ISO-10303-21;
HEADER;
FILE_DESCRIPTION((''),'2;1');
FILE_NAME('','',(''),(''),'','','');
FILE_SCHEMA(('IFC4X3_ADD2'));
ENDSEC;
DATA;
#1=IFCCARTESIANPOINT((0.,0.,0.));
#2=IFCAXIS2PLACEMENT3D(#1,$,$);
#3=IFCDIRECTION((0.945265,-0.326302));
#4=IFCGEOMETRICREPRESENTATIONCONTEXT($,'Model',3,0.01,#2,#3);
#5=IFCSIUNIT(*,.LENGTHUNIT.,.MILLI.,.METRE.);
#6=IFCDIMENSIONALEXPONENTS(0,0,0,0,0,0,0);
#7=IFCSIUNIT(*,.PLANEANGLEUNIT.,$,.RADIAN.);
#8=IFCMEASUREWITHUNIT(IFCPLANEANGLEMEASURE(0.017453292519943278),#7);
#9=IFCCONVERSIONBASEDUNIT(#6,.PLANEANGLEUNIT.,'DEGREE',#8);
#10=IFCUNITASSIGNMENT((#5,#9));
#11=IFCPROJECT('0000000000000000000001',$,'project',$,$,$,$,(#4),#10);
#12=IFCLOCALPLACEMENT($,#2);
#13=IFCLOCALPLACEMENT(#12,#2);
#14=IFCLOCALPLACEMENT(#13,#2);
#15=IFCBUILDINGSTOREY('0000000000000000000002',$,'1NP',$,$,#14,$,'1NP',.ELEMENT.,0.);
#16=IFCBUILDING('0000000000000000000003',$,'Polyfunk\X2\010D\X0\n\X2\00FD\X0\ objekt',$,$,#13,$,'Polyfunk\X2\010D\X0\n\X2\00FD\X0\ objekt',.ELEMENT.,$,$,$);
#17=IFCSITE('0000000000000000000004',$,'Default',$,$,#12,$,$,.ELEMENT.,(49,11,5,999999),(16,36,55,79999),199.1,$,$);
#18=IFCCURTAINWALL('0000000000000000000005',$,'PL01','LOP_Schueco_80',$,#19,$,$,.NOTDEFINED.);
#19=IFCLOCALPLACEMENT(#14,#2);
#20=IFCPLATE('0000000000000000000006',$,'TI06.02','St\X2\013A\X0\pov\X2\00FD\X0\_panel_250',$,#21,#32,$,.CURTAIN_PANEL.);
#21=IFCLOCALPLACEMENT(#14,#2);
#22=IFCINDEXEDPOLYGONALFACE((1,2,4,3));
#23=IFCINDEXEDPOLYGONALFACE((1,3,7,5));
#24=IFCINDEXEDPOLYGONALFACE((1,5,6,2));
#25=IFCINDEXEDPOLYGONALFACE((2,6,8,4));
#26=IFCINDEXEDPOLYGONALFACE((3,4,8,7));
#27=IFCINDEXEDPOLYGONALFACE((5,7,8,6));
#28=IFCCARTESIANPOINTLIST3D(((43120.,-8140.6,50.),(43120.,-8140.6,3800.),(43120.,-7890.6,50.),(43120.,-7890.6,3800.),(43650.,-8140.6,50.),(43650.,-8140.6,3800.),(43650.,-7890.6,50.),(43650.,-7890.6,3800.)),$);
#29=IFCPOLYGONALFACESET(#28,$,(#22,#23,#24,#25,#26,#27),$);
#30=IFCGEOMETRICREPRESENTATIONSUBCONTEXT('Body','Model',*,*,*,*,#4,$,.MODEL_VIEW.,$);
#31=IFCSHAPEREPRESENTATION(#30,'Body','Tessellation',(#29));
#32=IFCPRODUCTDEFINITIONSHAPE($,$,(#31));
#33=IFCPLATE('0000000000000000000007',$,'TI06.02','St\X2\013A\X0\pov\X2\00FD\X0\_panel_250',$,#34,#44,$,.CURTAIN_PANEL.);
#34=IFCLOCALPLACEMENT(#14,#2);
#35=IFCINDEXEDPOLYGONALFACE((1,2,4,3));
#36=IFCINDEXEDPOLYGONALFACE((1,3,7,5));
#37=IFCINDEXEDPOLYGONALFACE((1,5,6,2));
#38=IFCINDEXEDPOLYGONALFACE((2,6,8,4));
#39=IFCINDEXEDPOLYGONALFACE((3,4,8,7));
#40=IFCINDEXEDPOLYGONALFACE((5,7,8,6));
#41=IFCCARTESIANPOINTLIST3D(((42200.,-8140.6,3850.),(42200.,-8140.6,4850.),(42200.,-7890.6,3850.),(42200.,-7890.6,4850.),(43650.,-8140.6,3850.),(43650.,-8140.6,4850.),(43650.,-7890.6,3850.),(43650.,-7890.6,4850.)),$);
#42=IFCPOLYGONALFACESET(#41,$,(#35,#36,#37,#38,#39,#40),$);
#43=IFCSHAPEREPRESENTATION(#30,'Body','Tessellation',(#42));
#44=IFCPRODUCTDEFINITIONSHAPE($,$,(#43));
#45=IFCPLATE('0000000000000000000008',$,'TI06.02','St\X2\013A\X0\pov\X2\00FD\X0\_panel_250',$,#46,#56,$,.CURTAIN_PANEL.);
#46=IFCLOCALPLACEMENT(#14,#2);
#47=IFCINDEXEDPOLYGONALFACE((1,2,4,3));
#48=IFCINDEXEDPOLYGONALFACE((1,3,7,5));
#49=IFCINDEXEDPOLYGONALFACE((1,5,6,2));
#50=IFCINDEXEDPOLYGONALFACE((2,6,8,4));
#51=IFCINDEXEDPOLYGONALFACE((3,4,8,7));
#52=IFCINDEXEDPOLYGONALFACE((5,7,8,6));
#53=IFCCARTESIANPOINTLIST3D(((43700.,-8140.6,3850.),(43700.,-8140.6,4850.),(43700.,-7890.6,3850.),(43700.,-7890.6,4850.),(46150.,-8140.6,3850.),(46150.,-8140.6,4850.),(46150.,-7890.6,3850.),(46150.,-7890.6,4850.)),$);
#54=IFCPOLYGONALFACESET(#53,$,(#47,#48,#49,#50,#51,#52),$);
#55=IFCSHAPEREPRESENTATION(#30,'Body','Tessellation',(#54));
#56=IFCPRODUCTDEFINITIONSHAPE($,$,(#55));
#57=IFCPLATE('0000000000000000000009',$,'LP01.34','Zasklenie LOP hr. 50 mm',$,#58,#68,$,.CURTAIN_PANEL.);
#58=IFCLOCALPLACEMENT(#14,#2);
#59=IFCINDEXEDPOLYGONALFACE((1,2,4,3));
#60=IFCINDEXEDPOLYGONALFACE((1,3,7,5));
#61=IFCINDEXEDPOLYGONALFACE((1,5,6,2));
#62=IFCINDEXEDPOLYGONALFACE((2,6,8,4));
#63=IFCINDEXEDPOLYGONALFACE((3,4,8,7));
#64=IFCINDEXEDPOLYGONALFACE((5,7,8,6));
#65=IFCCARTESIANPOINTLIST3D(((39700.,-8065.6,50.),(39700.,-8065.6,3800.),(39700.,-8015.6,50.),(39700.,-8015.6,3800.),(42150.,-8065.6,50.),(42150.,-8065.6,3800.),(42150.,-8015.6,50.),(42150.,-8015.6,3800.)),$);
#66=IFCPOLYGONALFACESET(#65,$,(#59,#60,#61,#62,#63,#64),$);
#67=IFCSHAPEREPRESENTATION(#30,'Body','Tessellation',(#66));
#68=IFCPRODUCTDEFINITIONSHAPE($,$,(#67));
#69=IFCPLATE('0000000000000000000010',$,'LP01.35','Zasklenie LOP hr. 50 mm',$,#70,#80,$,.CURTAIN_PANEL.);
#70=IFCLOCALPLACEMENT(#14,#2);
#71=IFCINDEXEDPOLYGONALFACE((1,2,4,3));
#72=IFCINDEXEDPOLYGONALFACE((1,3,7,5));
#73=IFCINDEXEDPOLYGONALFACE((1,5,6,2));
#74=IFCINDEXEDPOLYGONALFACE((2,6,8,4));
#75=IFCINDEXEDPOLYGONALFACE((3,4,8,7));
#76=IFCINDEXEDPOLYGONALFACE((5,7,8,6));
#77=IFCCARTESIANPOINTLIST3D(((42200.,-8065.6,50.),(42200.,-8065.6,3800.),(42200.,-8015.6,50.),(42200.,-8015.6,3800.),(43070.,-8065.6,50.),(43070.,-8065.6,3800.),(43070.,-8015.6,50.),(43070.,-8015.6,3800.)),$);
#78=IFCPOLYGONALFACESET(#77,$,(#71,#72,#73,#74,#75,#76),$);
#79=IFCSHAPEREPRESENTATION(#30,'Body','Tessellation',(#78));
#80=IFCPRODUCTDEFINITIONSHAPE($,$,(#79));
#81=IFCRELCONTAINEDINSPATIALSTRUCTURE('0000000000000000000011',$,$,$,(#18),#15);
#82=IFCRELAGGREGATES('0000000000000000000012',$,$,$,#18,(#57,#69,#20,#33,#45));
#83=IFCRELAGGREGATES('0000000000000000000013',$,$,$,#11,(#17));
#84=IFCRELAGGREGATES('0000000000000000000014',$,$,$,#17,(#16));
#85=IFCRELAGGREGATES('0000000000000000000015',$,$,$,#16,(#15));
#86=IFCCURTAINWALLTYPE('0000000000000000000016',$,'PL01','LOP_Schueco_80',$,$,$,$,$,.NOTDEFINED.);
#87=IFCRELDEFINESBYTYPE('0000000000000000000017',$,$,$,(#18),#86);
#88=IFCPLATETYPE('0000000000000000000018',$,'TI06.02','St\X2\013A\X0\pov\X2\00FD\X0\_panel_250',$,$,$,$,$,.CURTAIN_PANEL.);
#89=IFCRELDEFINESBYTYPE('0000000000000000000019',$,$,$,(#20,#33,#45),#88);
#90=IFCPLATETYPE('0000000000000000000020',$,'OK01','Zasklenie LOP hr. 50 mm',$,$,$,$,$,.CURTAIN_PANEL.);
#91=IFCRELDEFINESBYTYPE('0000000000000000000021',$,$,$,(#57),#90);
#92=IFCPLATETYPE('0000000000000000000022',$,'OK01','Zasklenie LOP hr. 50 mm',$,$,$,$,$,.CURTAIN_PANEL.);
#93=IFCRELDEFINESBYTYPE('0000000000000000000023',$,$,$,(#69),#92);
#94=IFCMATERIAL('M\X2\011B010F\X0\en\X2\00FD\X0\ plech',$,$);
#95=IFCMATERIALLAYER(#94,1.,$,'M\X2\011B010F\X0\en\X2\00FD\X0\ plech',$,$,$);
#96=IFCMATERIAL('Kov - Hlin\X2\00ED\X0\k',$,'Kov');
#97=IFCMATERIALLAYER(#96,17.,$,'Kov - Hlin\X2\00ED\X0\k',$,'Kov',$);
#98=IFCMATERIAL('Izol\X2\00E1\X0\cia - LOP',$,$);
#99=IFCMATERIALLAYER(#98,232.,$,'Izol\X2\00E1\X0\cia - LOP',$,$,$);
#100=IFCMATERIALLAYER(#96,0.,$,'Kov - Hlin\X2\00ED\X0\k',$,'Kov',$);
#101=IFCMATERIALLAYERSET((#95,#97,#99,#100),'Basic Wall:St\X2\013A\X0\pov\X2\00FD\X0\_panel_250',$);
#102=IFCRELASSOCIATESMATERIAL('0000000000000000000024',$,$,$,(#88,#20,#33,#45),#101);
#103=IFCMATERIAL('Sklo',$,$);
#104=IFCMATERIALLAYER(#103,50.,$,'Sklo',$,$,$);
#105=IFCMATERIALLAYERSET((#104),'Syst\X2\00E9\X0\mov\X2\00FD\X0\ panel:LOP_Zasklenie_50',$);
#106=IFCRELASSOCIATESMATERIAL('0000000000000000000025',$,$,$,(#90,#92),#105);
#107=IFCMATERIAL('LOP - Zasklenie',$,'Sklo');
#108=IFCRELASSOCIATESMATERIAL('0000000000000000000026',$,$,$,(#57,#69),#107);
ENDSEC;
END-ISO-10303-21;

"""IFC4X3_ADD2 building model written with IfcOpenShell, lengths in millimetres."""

from ifc_helpers import new_model, entity, si_unit, converted_unit, direction, frame, frame_2d, origin, place, context, subcontext, project, spatial, rectangle, extrude, source, transform, mapped, material, layer, layer_set, layer_usage, type_object, type_shapes, element, aggregate, save


model = new_model("IFC4X3_ADD2")

# Units and contexts
model_context = context("Model", 3, precision=0.01, world=origin(), true_north=direction((0.945265, -0.326302)))
body_context = subcontext(model_context, "Body", "Model", "MODEL_VIEW")
ifc_project = project(units=[si_unit("LENGTHUNIT", "METRE", prefix="MILLI"), converted_unit("PLANEANGLEUNIT", "DEGREE", entity("IfcPlaneAngleMeasure", 0.017453292519943278), si_unit("PLANEANGLEUNIT", "RADIAN"), dimensions=[0, 0, 0, 0, 0, 0, 0])], contexts=[model_context])

# Site, building, storey
site_placement = place(None, origin())
site = spatial("IfcSite", under=ifc_project, at=site_placement, Name="Default", CompositionType="ELEMENT", RefLatitude=(49, 11, 5, 999999), RefLongitude=(16, 36, 55, 79999), RefElevation=199.1)
building_placement = place(site_placement, origin())
building = spatial("IfcBuilding", under=site, at=building_placement, Name="Polyfunkčný objekt", LongName="Polyfunkčný objekt", CompositionType="ELEMENT")
storey_placement = place(building_placement, origin())
storey = spatial("IfcBuildingStorey", under=building, at=storey_placement, Name="1NP", LongName="1NP", CompositionType="ELEMENT", Elevation=0.0)

# Curtain wall, plates
curtain_wall_type = type_object("IfcCurtainWallType", Name="PL01", Description="LOP_Schueco_80", PredefinedType="NOTDEFINED")
curtain_wall_placement = place(storey_placement, origin())
curtain_wall = element("IfcCurtainWall", 1, at=curtain_wall_placement, inside=storey, type_object=curtain_wall_type, Name="PL01", Description="LOP_Schueco_80", PredefinedType="NOTDEFINED")
ifc_material_1 = material(Name="Měďený plech")
ifc_layer_1 = layer(ifc_material_1, 1.0, Name="Měďený plech")
ifc_material_2 = material(Name="Kov - Hliník", Category="Kov")
ifc_layer_2 = layer(ifc_material_2, 17.0, Name="Kov - Hliník", Category="Kov")
ifc_material_3 = material(Name="Izolácia - LOP")
ifc_layer_3 = layer(ifc_material_3, 232.0, Name="Izolácia - LOP")
ifc_layer_4 = layer(ifc_material_2, 0.0, Name="Kov - Hliník", Category="Kov")
ifc_layer_set_1 = layer_set([ifc_layer_1, ifc_layer_2, ifc_layer_3, ifc_layer_4], Name="Basic Wall:Stĺpový_panel_250")
ifc_layer_usage_1 = layer_usage(ifc_layer_set_1, "AXIS2", "POSITIVE", -125.0)
plate_type_1 = type_object("IfcPlateType", Name="TI06.02", Description="Stĺpový_panel_250", PredefinedType="CURTAIN_PANEL", material=ifc_layer_set_1)
plate_1_placement = place(storey_placement, frame((43120.0, -8015.6, 50.0)))
plate_1 = element("IfcPlate", 2, at=plate_1_placement, type_object=plate_type_1, material=ifc_layer_usage_1, Name="TI06.02", Description="Stĺpový_panel_250", PredefinedType="CURTAIN_PANEL", context=body_context, shape_type="SweptSolid", body=[
    extrude(rectangle(XDim=250.0, YDim=530.0, at=frame_2d((0.0, 0.0), x_axis=(1.0, 0.0))), frame((265.0, 0.0, 0.0), z_axis=(0.0, 0.0, 1.0), x_axis=(0.0, 1.0, 0.0)), (0.0, 0.0, 1.0), 3750.0),
])
ifc_layer_usage_2 = layer_usage(ifc_layer_set_1, "AXIS2", "POSITIVE", -125.0)
plate_2_placement = place(storey_placement, frame((42200.0, -8015.6, 3850.0)))
plate_2 = element("IfcPlate", 3, at=plate_2_placement, type_object=plate_type_1, material=ifc_layer_usage_2, Name="TI06.02", Description="Stĺpový_panel_250", PredefinedType="CURTAIN_PANEL", context=body_context, shape_type="SweptSolid", body=[
    extrude(rectangle(XDim=250.0, YDim=1450.0, at=frame_2d((0.0, 0.0), x_axis=(1.0, 0.0))), frame((725.0, 0.0, 0.0), z_axis=(0.0, 0.0, 1.0), x_axis=(0.0, 1.0, 0.0)), (0.0, 0.0, 1.0), 1000.0),
])
ifc_layer_usage_3 = layer_usage(ifc_layer_set_1, "AXIS2", "POSITIVE", -125.0)
plate_3_placement = place(storey_placement, frame((43700.0, -8015.6, 3850.0)))
plate_3 = element("IfcPlate", 4, at=plate_3_placement, type_object=plate_type_1, material=ifc_layer_usage_3, Name="TI06.02", Description="Stĺpový_panel_250", PredefinedType="CURTAIN_PANEL", context=body_context, shape_type="SweptSolid", body=[
    extrude(rectangle(XDim=250.0, YDim=2450.0, at=frame_2d((0.0, 0.0), x_axis=(1.0, 0.0))), frame((1225.0, 0.0, 0.0), z_axis=(0.0, 0.0, 1.0), x_axis=(0.0, 1.0, 0.0)), (0.0, 0.0, 1.0), 1000.0),
])
ifc_material_4 = material(Name="LOP - Zasklenie", Category="Sklo")
ifc_material_5 = material(Name="Sklo")
ifc_layer_5 = layer(ifc_material_5, 50.0, Name="Sklo")
ifc_layer_set_2 = layer_set([ifc_layer_5], Name="Systémový panel:LOP_Zasklenie_50")
plate_type_2 = type_object("IfcPlateType", Name="OK01", Description="Zasklenie LOP hr. 50 mm", PredefinedType="CURTAIN_PANEL", material=ifc_layer_set_2)
shared_shape_1 = source(origin(), body_context, "Body", "SweptSolid", [
    extrude(rectangle(XDim=3750.0, YDim=2450.0, at=frame_2d((-331.2, 0.0), x_axis=(1.0, 0.0))), frame((0.0, -50.0, 2206.2), z_axis=(0.0, 1.0, 0.0), x_axis=(0.0, 0.0, 1.0)), (0.0, 0.0, 1.0), 50.0),
])
type_shapes(plate_type_2, [shared_shape_1])
plate_4_placement = place(curtain_wall_placement, frame((40925.0, -8015.6, 50.0)))
plate_4 = element("IfcPlate", 5, at=plate_4_placement, type_object=plate_type_2, material=ifc_material_4, Name="LP01.34", Description="Zasklenie LOP hr. 50 mm", PredefinedType="CURTAIN_PANEL", context=body_context, shape_type="MappedRepresentation", body=[
    mapped(shared_shape_1, transform((0.0, 0.0, 0.0), scale=1.0)),
])
plate_type_3 = type_object("IfcPlateType", Name="OK01", Description="Zasklenie LOP hr. 50 mm", PredefinedType="CURTAIN_PANEL", material=ifc_layer_set_2)
shared_shape_2 = source(origin(), body_context, "Body", "SweptSolid", [
    extrude(rectangle(XDim=3750.0, YDim=870.0, at=frame_2d((-331.2, 0.0), x_axis=(1.0, 0.0))), frame((0.0, -50.0, 2206.2), z_axis=(0.0, 1.0, 0.0), x_axis=(0.0, 0.0, 1.0)), (0.0, 0.0, 1.0), 50.0),
])
type_shapes(plate_type_3, [shared_shape_2])
plate_5_placement = place(curtain_wall_placement, frame((42635.0, -8015.6, 50.0)))
plate_5 = element("IfcPlate", 6, at=plate_5_placement, type_object=plate_type_3, material=ifc_material_4, Name="LP01.35", Description="Zasklenie LOP hr. 50 mm", PredefinedType="CURTAIN_PANEL", context=body_context, shape_type="MappedRepresentation", body=[
    mapped(shared_shape_2, transform((0.0, 0.0, 0.0), scale=1.0)),
])
aggregate(curtain_wall, [plate_4, plate_5, plate_1, plate_2, plate_3])

save(model, "model.ifc")
